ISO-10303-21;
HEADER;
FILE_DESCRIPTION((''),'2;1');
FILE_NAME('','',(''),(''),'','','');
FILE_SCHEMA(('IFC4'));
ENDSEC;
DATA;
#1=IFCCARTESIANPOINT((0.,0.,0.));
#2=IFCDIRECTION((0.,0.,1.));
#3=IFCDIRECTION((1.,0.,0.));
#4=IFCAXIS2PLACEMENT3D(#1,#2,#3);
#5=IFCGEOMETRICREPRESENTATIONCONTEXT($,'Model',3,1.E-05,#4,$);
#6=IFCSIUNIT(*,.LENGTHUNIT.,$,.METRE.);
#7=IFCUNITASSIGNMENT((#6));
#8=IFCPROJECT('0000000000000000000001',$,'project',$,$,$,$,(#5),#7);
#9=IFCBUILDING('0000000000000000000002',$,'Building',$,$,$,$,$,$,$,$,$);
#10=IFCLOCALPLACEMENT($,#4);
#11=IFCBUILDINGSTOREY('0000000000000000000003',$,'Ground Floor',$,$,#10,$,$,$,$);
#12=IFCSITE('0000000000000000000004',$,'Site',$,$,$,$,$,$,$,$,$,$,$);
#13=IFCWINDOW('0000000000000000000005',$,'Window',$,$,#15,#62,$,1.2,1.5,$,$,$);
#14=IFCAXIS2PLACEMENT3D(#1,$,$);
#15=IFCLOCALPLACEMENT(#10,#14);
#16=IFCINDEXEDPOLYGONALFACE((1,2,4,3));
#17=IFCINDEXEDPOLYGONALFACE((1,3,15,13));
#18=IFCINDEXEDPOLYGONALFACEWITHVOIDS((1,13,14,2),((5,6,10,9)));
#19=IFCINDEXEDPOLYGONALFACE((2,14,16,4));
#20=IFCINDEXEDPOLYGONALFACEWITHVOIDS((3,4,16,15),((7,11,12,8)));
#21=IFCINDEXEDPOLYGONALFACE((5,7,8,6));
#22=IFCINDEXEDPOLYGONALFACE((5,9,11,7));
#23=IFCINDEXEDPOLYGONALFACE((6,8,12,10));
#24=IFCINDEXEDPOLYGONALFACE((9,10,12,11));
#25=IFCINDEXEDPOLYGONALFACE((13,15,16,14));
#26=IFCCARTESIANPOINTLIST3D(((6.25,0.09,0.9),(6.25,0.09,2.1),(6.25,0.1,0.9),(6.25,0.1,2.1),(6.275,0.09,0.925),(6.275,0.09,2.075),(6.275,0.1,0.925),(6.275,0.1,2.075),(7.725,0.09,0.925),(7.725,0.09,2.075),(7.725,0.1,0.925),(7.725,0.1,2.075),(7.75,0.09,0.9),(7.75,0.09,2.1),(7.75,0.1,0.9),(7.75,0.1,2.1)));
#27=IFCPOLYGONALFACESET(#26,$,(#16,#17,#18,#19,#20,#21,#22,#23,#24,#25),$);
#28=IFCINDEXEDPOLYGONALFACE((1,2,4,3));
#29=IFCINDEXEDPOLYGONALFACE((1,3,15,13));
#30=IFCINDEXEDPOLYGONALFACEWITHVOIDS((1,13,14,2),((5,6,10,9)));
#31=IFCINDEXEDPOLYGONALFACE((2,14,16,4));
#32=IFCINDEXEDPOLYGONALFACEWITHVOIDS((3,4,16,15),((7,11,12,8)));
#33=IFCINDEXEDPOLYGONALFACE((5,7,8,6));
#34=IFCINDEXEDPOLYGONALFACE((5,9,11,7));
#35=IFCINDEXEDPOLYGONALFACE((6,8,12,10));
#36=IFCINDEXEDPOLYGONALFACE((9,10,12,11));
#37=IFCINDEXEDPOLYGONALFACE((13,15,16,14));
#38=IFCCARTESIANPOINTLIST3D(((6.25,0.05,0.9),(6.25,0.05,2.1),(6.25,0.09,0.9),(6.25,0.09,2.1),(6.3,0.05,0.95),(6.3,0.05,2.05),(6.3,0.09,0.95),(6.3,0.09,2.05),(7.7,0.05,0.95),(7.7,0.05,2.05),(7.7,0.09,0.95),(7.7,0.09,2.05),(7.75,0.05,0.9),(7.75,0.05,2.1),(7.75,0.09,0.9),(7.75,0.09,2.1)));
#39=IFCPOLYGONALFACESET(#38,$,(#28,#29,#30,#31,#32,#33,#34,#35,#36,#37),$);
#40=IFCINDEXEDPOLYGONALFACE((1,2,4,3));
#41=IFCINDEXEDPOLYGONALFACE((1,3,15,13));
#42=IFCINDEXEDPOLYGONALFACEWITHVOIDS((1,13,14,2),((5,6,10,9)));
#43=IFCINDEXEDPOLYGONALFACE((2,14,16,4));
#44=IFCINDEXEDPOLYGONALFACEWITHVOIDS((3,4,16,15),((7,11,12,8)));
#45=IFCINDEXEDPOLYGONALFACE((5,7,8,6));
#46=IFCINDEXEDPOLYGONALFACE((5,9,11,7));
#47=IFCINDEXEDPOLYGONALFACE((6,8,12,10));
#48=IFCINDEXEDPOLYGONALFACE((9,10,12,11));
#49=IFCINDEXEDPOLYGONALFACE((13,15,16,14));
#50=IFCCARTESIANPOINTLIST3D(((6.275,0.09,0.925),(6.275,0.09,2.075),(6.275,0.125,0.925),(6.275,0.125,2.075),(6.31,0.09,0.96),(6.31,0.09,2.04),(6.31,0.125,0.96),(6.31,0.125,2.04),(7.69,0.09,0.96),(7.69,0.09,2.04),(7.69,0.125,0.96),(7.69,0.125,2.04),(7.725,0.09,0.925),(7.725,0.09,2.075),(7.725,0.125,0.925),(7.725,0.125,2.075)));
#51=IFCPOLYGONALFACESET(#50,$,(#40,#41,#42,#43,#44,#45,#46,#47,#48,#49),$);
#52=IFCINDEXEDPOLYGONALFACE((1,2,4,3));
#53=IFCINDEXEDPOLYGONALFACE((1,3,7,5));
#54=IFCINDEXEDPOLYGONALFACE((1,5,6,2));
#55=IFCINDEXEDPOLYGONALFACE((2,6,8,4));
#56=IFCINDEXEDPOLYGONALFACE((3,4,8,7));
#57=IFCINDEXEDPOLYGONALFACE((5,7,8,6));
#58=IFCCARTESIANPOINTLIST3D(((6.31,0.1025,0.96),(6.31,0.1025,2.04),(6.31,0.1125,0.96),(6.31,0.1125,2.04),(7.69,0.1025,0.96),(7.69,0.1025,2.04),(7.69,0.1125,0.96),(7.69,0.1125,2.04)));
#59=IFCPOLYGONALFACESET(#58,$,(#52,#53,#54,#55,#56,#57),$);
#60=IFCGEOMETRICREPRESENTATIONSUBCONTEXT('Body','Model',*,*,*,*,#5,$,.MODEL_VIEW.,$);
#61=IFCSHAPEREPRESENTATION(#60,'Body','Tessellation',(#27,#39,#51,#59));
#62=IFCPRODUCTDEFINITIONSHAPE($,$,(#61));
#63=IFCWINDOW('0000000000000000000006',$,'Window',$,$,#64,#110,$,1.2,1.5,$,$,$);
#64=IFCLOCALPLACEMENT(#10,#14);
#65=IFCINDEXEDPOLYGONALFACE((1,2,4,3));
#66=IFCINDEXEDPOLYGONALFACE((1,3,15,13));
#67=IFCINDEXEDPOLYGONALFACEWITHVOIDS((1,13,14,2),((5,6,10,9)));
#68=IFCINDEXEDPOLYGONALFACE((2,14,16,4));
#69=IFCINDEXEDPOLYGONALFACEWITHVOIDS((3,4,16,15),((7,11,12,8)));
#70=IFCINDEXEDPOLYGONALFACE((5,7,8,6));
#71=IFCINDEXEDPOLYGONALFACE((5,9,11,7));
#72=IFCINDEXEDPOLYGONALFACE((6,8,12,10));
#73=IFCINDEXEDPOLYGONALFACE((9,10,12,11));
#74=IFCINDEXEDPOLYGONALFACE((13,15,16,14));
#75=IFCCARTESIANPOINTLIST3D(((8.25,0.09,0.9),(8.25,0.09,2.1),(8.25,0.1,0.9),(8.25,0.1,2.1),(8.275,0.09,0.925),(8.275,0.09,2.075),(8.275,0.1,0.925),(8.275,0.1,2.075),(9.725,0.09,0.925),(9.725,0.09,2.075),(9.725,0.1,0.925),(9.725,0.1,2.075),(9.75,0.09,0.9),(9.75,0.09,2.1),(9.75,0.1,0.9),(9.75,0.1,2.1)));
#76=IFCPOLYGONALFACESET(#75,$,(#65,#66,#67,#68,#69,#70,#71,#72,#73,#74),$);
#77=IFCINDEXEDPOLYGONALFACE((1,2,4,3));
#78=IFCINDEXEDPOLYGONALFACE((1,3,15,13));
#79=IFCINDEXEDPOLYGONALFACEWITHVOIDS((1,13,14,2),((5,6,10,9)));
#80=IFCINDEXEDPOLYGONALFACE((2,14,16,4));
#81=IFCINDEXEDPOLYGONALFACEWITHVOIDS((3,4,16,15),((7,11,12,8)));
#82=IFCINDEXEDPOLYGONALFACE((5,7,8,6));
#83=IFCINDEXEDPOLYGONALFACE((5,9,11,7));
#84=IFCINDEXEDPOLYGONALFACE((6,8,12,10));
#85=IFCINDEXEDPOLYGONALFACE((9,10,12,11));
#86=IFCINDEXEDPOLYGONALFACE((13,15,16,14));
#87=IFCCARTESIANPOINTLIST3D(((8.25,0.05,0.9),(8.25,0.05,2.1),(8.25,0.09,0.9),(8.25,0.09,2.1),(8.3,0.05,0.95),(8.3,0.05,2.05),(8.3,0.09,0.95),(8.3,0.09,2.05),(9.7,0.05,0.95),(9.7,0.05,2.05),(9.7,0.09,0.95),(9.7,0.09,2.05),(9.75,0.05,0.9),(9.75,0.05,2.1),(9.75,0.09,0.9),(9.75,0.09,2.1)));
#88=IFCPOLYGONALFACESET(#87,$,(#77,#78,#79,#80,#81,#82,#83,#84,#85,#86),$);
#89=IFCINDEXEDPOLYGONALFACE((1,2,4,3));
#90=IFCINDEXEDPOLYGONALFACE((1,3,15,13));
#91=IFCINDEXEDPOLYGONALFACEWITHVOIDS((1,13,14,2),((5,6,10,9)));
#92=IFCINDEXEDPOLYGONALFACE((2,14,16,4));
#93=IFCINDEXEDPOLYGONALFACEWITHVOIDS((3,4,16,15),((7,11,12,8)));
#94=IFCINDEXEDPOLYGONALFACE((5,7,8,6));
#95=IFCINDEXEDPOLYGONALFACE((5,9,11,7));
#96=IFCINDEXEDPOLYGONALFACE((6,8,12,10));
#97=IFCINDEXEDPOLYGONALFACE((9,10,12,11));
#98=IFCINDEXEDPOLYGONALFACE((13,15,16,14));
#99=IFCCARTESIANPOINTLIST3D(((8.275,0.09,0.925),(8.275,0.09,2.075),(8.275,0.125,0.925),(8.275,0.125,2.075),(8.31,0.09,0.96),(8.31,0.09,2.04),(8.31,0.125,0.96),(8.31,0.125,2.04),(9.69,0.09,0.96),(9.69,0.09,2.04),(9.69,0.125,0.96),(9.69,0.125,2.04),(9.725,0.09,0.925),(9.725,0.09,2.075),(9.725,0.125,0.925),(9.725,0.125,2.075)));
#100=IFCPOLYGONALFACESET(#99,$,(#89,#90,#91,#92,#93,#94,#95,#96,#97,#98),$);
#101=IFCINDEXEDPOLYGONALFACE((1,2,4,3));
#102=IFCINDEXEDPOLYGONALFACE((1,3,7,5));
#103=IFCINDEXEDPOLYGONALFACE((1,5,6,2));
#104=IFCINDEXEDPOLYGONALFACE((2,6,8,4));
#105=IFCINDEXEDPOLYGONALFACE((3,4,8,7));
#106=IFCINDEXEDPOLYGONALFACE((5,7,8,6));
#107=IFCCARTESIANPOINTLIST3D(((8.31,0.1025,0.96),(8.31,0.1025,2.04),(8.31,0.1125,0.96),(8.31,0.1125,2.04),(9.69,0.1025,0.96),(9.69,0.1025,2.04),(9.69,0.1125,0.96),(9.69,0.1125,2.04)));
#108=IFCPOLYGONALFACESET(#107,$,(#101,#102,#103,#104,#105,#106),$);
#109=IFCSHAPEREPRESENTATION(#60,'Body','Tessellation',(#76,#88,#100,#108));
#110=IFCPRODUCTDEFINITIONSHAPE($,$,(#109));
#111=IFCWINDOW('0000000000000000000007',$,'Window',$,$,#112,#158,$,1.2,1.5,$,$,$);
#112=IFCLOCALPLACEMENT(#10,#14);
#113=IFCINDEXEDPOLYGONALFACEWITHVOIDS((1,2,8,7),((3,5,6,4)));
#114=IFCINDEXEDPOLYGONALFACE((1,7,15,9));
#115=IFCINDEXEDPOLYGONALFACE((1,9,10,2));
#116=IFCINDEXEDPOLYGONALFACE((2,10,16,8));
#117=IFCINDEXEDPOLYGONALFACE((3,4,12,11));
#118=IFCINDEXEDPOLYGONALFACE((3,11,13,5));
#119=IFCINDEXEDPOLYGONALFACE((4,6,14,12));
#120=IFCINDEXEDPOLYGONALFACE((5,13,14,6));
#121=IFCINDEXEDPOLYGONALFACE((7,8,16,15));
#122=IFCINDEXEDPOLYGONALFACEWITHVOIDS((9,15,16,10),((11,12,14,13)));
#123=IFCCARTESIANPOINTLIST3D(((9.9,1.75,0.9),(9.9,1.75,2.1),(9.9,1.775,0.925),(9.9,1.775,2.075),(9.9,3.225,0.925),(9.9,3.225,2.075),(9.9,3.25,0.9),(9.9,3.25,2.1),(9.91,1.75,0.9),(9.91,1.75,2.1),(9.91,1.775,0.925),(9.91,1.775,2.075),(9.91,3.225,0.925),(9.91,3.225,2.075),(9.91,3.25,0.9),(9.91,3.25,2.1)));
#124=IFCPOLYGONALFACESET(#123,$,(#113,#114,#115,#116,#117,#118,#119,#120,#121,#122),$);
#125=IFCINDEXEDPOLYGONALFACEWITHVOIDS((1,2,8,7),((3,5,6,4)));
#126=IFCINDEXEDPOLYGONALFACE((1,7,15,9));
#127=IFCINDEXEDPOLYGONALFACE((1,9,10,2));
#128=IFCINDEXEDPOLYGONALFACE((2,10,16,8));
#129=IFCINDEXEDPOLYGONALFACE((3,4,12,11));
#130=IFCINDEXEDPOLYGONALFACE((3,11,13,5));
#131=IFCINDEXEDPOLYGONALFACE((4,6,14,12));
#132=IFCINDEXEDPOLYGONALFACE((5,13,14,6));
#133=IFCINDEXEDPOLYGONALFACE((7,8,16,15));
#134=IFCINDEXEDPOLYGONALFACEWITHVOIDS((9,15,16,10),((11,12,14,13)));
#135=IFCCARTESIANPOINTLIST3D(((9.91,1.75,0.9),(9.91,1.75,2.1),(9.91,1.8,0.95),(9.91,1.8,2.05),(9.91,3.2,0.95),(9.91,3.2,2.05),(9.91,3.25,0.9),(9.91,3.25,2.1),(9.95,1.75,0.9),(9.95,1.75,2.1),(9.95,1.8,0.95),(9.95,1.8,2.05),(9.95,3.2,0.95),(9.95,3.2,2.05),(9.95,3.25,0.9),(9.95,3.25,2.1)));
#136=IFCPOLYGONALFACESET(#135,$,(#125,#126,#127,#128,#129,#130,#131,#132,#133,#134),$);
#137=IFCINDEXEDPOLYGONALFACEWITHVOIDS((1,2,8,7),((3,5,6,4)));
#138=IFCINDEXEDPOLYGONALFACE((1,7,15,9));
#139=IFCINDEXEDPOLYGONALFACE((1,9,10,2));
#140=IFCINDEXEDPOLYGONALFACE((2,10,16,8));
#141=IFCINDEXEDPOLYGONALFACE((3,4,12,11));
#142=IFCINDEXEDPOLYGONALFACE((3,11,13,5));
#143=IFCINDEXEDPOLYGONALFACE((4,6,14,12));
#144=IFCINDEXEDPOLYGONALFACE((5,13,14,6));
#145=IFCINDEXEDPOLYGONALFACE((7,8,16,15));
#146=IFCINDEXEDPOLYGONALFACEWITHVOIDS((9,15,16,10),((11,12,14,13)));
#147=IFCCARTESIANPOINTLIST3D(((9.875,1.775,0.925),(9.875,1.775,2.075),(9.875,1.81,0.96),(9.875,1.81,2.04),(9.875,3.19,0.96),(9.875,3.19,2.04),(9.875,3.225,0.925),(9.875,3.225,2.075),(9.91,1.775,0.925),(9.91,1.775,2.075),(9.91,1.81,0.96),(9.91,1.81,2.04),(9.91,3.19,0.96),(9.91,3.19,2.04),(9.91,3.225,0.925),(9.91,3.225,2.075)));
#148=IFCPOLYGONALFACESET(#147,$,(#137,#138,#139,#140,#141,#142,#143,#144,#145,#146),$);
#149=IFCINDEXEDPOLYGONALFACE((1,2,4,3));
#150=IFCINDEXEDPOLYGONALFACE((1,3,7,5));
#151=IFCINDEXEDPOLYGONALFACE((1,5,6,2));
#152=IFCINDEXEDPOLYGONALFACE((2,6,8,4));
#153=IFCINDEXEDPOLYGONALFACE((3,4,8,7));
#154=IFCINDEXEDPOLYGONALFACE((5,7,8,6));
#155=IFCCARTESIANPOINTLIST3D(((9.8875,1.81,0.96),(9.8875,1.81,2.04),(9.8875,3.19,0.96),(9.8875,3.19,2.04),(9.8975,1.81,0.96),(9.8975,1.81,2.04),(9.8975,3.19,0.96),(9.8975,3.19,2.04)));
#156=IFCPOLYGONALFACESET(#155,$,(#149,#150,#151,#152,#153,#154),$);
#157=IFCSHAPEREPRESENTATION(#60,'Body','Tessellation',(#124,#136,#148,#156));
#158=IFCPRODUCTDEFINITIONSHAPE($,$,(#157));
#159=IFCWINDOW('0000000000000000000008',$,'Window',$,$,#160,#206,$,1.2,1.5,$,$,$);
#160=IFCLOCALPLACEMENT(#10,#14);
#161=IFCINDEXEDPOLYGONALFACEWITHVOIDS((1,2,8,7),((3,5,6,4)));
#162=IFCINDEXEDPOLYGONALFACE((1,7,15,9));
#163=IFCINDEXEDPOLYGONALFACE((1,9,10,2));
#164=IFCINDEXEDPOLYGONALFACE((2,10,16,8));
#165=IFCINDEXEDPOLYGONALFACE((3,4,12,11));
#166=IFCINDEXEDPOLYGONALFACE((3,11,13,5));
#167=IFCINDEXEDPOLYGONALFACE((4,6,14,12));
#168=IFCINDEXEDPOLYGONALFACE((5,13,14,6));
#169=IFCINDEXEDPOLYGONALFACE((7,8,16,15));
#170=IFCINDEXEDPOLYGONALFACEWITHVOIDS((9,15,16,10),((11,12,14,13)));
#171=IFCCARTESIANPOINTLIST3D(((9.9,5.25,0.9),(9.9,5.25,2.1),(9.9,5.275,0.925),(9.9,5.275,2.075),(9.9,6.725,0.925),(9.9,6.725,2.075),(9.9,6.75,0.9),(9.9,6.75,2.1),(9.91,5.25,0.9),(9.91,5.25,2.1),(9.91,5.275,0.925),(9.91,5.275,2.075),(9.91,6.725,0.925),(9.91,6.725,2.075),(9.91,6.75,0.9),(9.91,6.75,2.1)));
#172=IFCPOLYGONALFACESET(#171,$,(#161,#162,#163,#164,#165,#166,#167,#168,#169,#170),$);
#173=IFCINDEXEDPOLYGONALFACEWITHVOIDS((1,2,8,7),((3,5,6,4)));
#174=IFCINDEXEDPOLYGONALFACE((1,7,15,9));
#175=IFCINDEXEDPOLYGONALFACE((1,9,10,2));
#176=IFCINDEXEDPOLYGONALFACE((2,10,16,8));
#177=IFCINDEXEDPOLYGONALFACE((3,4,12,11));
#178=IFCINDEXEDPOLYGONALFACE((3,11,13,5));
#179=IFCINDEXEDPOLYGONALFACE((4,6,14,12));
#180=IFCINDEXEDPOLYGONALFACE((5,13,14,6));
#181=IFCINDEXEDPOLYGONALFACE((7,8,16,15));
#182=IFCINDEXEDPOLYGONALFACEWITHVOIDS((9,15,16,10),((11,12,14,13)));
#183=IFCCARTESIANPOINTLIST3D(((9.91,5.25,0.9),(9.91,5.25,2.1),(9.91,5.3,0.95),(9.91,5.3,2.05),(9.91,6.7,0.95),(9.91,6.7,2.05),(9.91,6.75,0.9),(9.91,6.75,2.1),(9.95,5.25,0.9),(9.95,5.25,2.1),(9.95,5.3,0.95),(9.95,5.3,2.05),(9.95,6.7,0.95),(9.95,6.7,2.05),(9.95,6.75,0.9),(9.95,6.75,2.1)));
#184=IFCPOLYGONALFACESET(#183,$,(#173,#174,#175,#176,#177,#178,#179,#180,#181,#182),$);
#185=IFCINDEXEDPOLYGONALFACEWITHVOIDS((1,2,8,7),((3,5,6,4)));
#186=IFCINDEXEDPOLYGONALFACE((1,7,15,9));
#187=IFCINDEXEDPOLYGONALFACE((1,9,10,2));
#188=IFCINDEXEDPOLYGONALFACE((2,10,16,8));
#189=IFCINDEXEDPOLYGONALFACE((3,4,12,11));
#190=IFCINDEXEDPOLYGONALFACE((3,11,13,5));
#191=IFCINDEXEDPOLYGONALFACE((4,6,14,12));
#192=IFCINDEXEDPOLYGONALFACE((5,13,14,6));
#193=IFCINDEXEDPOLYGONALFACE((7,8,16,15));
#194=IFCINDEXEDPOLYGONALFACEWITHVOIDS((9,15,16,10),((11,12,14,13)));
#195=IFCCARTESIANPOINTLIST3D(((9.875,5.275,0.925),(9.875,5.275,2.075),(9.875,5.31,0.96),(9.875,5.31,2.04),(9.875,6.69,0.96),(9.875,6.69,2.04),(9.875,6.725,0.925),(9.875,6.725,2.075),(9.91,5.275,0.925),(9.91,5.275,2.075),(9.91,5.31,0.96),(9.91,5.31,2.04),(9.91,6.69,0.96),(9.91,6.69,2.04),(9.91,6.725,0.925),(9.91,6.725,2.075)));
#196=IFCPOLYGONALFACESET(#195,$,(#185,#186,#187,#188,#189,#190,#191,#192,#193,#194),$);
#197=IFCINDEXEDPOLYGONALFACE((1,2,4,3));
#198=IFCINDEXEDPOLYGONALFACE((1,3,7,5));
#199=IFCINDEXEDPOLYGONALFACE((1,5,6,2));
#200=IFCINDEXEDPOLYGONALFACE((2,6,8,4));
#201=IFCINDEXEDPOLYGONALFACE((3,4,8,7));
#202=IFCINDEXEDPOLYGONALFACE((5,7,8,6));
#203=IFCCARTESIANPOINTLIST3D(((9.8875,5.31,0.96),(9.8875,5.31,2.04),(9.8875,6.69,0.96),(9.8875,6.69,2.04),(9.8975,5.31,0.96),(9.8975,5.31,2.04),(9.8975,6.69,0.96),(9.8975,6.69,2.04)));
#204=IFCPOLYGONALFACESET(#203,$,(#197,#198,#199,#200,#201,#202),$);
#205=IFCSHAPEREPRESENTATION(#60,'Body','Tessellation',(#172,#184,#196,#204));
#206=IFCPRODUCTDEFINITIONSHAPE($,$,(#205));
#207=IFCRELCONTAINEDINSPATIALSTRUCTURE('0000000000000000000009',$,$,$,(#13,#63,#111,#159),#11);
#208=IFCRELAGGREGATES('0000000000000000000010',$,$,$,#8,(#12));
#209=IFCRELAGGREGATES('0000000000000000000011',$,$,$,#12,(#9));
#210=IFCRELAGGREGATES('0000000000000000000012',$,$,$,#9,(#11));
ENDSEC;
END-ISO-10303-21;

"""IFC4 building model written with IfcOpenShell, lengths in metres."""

from ifc_helpers import new_model, si_unit, frame, origin_with_axes, place, context, subcontext, project, spatial, line, indexed_curve, outline, extrude, element, save


model = new_model("IFC4")

# Units and contexts
model_context = context("Model", 3, precision=1e-05, world=origin_with_axes())
body_context = subcontext(model_context, "Body", "Model", "MODEL_VIEW")
ifc_project = project(units=[si_unit("LENGTHUNIT", "METRE")], contexts=[model_context])

# Site, building, storey
site = spatial("IfcSite", under=ifc_project, Name="Site")
building = spatial("IfcBuilding", under=site, Name="Building")
storey_placement = place(None, origin_with_axes())
storey = spatial("IfcBuildingStorey", under=building, at=storey_placement, Name="Ground Floor")

# Windows
for number, where, z_axis, x_axis, name in (
    (1, (6.25, 0.0, 0.9), (0.0, 0.0, 1.0), (1.0, 0.0, 0.0), "Window"),
    (2, (8.25, 0.0, 0.9), (0.0, 0.0, 1.0), (1.0, 0.0, 0.0), "Window"),
    (3, (10.0, 1.75, 0.9), (0.0, 0.0, 1.0), (0.0, 1.0, 0.0), "Window"),
    (4, (10.0, 5.25, 0.9), (0.0, 0.0, 1.0), (0.0, 1.0, 0.0), "Window"),
):
    element("IfcWindow", number, at=place(storey_placement, frame(where, z_axis=z_axis, x_axis=x_axis)), inside=storey, Name=name, OverallHeight=1.2, OverallWidth=1.5, context=body_context, shape_type="SweptSolid", body=[
        extrude(outline(indexed_curve([(0.0, 0.0), (1.5, 0.0), (1.5, 1.2), (0.0, 1.2)], segments=[line(1, 2, 3, 4, 1)]), holes=[indexed_curve([(0.025, 0.025), (1.475, 0.025), (1.475, 1.175), (0.025, 1.175)], segments=[line(1, 2, 3, 4, 1)])]), frame((0.0, 0.09, 0.0), z_axis=(0.0, -1.0, 0.0), x_axis=(1.0, 0.0, 0.0)), (0.0, 0.0, -1.0), 0.01),
        extrude(outline(indexed_curve([(0.0, 0.0), (1.5, 0.0), (1.5, 1.2), (0.0, 1.2)], segments=[line(1, 2, 3, 4, 1)]), holes=[indexed_curve([(0.05, 0.05), (1.45, 0.05), (1.45, 1.15), (0.05, 1.15)], segments=[line(1, 2, 3, 4, 1)])]), frame((0.0, 0.05, 0.0), z_axis=(0.0, -1.0, 0.0), x_axis=(1.0, 0.0, 0.0)), (0.0, 0.0, -1.0), 0.04),
        extrude(outline(indexed_curve([(0.0, 0.0), (1.45, 0.0), (1.45, 1.15), (0.0, 1.15)], segments=[line(1, 2, 3, 4, 1)]), holes=[indexed_curve([(0.035, 0.035), (1.415, 0.035), (1.415, 1.115), (0.035, 1.115)], segments=[line(1, 2, 3, 4, 1)])]), frame((0.025, 0.09, 0.025), z_axis=(0.0, -1.0, 0.0), x_axis=(1.0, 0.0, 0.0)), (0.0, 0.0, -1.0), 0.035),
        extrude(outline(indexed_curve([(0.035, 0.035), (1.415, 0.035), (1.415, 1.115), (0.035, 1.115)], segments=[line(1, 2, 3, 4, 1)])), frame((0.025, 0.1025, 0.025), z_axis=(0.0, -1.0, 0.0), x_axis=(1.0, 0.0, 0.0)), (0.0, 0.0, -1.0), 0.01),
    ])

save(model, "model.ifc")
